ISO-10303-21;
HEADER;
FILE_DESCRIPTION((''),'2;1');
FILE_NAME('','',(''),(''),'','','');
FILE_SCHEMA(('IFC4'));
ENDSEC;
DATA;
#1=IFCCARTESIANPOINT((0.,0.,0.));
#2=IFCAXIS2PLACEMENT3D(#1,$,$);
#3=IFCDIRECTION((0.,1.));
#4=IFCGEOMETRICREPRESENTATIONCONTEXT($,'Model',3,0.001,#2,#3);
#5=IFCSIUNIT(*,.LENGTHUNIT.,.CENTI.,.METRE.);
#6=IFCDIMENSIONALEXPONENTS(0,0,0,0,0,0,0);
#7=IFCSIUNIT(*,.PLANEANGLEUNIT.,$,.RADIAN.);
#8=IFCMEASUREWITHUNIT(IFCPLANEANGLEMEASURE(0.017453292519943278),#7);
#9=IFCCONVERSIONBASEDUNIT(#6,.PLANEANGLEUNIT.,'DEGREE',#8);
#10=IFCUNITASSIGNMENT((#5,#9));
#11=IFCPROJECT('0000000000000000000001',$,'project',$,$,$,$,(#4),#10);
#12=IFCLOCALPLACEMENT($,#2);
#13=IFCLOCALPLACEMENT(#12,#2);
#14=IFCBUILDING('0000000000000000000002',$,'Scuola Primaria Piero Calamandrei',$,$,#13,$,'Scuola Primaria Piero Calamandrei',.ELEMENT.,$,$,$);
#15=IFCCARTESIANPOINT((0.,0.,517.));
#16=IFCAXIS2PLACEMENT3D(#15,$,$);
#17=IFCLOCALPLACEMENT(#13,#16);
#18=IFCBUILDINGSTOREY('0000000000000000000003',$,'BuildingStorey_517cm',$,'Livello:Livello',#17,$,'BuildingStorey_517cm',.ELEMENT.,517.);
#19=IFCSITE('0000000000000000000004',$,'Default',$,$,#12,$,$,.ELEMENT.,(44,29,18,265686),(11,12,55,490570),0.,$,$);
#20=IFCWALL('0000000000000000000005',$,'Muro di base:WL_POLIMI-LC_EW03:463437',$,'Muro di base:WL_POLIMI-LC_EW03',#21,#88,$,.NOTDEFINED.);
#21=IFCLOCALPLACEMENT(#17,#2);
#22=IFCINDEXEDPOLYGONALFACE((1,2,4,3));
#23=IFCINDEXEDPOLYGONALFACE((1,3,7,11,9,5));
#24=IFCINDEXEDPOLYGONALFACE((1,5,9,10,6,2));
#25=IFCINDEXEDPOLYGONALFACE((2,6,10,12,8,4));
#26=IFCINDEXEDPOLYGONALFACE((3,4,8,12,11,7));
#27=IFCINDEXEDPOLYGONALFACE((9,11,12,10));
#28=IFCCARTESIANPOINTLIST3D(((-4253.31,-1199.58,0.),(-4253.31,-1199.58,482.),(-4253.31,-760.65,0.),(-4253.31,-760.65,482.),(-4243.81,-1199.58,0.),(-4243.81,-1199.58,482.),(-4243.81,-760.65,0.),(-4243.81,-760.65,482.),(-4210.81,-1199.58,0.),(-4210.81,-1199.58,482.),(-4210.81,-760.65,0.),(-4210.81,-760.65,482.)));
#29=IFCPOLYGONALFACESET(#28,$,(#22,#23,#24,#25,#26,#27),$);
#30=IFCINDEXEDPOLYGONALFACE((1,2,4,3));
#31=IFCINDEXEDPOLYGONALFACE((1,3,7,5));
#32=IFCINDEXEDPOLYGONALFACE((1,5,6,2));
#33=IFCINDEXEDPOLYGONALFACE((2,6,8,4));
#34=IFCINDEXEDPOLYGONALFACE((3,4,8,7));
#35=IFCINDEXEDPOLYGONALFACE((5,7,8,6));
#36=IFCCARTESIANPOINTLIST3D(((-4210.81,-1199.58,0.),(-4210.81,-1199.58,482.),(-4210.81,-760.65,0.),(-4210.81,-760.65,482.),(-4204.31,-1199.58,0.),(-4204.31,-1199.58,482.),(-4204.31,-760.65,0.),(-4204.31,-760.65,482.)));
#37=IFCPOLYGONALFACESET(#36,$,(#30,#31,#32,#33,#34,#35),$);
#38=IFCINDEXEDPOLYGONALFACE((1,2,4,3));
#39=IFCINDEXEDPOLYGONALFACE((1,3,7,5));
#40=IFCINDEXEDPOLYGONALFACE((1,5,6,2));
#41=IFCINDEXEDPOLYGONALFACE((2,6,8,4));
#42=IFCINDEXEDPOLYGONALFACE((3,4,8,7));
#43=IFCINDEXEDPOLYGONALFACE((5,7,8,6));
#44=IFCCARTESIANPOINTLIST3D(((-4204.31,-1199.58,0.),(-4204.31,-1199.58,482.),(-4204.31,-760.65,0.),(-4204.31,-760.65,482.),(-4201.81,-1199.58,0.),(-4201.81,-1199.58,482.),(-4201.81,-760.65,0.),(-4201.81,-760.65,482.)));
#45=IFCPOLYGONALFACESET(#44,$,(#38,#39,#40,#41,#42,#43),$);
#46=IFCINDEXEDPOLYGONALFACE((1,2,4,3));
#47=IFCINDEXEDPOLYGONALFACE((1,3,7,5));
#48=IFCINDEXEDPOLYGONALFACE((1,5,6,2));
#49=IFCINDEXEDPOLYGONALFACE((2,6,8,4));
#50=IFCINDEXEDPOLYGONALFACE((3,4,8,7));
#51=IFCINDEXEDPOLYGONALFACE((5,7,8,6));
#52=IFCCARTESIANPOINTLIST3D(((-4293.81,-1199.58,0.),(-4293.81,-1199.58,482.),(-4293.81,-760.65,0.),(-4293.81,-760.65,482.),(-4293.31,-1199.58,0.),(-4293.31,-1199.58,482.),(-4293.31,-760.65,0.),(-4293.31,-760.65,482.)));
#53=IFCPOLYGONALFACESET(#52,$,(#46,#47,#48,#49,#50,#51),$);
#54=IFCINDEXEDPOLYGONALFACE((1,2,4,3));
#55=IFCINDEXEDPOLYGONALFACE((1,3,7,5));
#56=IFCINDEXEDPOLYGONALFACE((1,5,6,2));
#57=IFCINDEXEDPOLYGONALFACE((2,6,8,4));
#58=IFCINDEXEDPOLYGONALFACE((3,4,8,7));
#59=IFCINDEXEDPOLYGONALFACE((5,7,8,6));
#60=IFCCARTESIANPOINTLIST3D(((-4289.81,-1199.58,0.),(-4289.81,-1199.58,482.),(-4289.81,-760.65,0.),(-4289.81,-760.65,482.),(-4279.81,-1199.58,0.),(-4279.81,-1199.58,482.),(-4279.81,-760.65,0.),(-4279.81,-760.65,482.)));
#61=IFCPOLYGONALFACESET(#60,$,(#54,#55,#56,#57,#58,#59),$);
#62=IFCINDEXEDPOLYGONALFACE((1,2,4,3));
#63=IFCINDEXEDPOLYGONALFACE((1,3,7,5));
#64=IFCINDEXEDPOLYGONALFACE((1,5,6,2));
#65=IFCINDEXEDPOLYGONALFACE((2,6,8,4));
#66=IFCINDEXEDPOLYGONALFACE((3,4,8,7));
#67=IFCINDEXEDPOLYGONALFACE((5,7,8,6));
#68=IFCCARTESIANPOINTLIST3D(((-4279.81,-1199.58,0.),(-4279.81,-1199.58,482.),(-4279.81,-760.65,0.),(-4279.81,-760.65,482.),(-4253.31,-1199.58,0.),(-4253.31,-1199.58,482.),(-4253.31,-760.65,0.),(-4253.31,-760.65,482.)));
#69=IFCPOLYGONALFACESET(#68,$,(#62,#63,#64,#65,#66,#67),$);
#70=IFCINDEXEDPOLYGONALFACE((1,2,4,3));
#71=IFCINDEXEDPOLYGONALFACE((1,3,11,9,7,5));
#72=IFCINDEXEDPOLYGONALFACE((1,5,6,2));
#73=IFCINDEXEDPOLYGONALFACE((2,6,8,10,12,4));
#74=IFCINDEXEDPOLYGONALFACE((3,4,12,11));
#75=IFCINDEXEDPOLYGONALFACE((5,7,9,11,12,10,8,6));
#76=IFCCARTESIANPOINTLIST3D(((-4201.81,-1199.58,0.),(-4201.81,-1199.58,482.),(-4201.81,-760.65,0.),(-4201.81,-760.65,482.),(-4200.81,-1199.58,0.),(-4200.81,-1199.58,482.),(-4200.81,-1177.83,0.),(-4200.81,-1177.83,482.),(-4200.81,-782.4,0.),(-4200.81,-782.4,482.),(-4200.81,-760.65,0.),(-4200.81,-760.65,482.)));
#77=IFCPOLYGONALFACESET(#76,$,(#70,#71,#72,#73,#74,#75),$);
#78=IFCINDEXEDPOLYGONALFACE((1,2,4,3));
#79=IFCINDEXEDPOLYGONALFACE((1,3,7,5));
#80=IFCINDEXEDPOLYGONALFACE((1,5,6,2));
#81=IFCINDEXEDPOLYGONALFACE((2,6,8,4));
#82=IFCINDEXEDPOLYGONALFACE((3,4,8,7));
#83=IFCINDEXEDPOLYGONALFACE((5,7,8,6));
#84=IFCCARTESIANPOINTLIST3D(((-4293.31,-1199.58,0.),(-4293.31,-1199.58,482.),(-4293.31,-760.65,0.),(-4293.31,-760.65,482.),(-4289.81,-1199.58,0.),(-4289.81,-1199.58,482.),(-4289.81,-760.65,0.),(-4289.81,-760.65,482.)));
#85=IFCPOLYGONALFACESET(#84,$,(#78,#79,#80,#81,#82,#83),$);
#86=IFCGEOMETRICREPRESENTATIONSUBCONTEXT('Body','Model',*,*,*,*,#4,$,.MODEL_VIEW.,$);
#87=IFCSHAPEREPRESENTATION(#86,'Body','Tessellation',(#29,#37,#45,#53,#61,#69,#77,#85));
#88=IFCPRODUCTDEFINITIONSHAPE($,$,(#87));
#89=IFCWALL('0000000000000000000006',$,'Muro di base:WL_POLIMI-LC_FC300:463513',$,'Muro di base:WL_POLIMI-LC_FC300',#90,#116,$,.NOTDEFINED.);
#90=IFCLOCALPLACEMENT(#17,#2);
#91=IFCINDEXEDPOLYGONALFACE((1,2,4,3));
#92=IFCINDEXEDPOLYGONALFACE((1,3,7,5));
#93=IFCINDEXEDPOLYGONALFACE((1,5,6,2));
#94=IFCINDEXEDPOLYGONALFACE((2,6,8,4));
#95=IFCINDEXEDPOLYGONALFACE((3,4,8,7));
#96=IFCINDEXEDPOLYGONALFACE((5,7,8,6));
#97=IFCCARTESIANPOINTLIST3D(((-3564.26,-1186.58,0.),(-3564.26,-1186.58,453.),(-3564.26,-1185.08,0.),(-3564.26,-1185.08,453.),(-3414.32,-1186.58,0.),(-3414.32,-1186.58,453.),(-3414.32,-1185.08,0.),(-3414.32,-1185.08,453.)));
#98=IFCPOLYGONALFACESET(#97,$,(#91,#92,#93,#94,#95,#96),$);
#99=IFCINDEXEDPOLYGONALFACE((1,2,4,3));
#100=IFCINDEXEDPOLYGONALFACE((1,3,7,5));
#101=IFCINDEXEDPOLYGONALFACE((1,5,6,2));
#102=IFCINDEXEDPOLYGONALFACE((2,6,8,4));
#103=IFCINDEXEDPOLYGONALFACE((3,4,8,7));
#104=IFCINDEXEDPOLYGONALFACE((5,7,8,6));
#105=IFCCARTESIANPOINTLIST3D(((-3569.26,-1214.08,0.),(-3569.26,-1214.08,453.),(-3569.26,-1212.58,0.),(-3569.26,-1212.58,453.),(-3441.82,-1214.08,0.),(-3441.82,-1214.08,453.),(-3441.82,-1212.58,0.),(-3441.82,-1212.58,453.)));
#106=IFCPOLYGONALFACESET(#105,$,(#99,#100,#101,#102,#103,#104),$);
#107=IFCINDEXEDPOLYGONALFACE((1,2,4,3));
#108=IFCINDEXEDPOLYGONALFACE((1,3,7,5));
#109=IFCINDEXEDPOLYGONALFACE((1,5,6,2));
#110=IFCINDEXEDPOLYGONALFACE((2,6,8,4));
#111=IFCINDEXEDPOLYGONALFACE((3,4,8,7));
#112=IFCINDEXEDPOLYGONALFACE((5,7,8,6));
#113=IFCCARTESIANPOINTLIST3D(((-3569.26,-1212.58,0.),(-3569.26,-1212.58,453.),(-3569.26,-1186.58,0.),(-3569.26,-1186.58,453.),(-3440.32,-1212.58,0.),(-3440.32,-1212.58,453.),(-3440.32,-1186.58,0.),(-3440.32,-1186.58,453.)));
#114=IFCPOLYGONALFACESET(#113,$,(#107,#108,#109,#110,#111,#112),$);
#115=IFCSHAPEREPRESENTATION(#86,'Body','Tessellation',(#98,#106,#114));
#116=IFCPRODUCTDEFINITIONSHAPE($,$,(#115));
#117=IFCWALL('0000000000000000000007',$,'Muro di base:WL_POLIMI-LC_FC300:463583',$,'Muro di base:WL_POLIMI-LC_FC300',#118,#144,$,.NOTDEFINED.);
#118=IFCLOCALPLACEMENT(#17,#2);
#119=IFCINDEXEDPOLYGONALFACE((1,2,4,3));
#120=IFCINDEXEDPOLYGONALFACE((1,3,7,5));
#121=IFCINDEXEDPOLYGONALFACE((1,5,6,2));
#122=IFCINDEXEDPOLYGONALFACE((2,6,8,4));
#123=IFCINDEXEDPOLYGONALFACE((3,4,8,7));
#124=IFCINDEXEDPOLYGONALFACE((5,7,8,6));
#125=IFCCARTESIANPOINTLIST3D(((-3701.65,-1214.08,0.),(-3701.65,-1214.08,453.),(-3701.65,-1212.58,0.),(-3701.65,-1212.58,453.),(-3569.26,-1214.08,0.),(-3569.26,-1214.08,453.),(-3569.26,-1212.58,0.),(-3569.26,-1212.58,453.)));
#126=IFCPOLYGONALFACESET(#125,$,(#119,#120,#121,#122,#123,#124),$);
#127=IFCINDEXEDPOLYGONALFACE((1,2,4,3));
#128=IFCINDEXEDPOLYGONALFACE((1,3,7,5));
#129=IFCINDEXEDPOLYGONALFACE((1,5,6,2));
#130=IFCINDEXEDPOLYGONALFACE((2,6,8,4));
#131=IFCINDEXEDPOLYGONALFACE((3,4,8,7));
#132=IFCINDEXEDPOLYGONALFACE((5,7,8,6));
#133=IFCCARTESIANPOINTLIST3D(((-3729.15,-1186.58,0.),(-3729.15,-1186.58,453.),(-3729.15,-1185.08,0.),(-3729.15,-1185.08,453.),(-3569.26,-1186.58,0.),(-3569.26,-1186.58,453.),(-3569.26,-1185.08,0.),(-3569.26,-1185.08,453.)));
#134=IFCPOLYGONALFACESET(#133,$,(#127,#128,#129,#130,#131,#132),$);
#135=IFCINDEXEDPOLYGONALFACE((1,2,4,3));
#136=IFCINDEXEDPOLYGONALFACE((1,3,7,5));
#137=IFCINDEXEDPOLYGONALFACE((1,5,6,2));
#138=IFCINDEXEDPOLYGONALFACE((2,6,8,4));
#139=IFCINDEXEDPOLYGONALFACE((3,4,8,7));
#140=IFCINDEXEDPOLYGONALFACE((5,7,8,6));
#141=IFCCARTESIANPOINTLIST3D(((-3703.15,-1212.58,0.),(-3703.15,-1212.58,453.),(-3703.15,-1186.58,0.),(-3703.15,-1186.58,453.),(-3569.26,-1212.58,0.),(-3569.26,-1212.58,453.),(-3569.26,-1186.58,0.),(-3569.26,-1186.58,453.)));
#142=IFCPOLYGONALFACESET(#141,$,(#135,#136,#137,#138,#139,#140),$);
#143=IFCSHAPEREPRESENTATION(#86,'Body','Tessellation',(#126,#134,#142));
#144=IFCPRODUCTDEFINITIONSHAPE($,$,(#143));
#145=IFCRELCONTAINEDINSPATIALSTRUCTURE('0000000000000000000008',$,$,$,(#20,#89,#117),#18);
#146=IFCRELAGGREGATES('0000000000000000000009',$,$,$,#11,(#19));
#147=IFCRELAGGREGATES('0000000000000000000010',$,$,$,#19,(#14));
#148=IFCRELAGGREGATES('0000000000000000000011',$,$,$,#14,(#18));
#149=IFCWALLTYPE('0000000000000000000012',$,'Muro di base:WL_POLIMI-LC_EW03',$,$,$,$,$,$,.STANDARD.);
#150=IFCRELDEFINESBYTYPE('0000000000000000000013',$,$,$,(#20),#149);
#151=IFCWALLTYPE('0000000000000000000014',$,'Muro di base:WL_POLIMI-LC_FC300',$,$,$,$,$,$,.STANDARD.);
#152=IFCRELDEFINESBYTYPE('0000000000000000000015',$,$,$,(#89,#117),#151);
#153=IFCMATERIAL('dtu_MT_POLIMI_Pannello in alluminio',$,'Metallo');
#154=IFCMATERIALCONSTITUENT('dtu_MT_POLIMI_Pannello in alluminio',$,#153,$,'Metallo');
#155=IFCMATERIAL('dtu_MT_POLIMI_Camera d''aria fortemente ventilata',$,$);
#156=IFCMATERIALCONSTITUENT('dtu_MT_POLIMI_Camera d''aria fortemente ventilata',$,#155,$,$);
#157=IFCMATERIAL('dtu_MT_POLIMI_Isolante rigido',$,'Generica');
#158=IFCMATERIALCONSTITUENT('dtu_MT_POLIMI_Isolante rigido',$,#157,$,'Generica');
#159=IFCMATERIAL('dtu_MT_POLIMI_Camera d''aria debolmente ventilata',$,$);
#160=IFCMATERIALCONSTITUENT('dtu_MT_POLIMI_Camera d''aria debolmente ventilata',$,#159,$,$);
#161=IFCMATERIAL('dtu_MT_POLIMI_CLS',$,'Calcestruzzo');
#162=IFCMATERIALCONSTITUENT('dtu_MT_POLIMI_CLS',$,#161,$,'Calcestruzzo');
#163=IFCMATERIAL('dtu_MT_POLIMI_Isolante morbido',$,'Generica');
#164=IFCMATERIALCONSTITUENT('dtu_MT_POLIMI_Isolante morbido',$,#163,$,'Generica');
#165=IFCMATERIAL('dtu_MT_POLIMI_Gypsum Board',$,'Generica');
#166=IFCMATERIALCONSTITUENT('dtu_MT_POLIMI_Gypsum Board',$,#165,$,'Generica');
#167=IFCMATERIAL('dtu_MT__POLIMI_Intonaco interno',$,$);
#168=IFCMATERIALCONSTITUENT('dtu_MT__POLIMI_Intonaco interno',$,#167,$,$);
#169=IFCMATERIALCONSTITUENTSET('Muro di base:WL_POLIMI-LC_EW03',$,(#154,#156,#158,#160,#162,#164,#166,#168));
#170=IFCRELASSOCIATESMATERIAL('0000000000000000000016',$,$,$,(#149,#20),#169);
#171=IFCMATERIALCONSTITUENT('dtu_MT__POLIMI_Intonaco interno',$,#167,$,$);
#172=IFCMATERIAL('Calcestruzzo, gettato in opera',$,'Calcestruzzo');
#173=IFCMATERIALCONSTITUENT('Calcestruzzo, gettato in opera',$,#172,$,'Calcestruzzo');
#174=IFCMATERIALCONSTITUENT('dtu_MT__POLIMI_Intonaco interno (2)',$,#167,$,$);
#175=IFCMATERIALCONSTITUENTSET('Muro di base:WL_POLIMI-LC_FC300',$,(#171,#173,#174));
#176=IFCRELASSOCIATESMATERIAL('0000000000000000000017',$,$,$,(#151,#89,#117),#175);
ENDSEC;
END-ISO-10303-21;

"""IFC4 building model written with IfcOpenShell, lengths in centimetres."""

from ifc_helpers import new_model, entity, si_unit, converted_unit, direction, frame, origin, place, context, subcontext, project, spatial, indexed_curve, outline, extrude, material, constituent, constituent_set, type_object, element, save


model = new_model("IFC4")

# Units and contexts
model_context = context("Model", 3, precision=0.001, world=origin(), true_north=direction((0.0, 1.0)))
body_context = subcontext(model_context, "Body", "Model", "MODEL_VIEW")
ifc_project = project(units=[si_unit("LENGTHUNIT", "METRE", prefix="CENTI"), converted_unit("PLANEANGLEUNIT", "DEGREE", entity("IfcPlaneAngleMeasure", 0.017453292519943278), si_unit("PLANEANGLEUNIT", "RADIAN"), dimensions=[0, 0, 0, 0, 0, 0, 0])], contexts=[model_context])

# Site, building, storey
site_placement = place(None, origin())
site = spatial("IfcSite", under=ifc_project, at=site_placement, Name="Default", CompositionType="ELEMENT", RefLatitude=(44, 29, 18, 265686), RefLongitude=(11, 12, 55, 490570), RefElevation=0.0)
building_placement = place(site_placement, origin())
building = spatial("IfcBuilding", under=site, at=building_placement, Name="Scuola Primaria Piero Calamandrei", LongName="Scuola Primaria Piero Calamandrei", CompositionType="ELEMENT")
storey_placement = place(building_placement, frame((0.0, 0.0, 517.0)))
storey = spatial("IfcBuildingStorey", under=building, at=storey_placement, Name="BuildingStorey_517cm", ObjectType="Livello:Livello", LongName="BuildingStorey_517cm", CompositionType="ELEMENT", Elevation=517.0)

# Wall
ifc_material_1 = material(Name="dtu_MT_POLIMI_Pannello in alluminio", Category="Metallo")
ifc_material_2 = material(Name="dtu_MT_POLIMI_Camera d'aria fortemente ventilata")
ifc_material_3 = material(Name="dtu_MT_POLIMI_Isolante rigido", Category="Generica")
ifc_material_4 = material(Name="dtu_MT_POLIMI_Camera d'aria debolmente ventilata")
ifc_material_5 = material(Name="dtu_MT_POLIMI_Isolante morbido", Category="Generica")
ifc_material_6 = material(Name="dtu_MT_POLIMI_Gypsum Board", Category="Generica")
ifc_material_7 = material(Name="dtu_MT__POLIMI_Intonaco interno")
ifc_constituent_1 = constituent(ifc_material_1, Name="dtu_MT_POLIMI_Pannello in alluminio", Category="Metallo")
ifc_constituent_2 = constituent(ifc_material_2, Name="dtu_MT_POLIMI_Camera d'aria fortemente ventilata")
ifc_constituent_3 = constituent(ifc_material_3, Name="dtu_MT_POLIMI_Isolante rigido", Category="Generica")
ifc_constituent_4 = constituent(ifc_material_4, Name="dtu_MT_POLIMI_Camera d'aria debolmente ventilata")
ifc_material_8 = material(Name="dtu_MT_POLIMI_CLS", Category="Calcestruzzo")
ifc_constituent_5 = constituent(ifc_material_8, Name="dtu_MT_POLIMI_CLS", Category="Calcestruzzo")
ifc_constituent_6 = constituent(ifc_material_5, Name="dtu_MT_POLIMI_Isolante morbido", Category="Generica")
ifc_constituent_7 = constituent(ifc_material_6, Name="dtu_MT_POLIMI_Gypsum Board", Category="Generica")
ifc_constituent_8 = constituent(ifc_material_7, Name="dtu_MT__POLIMI_Intonaco interno")
ifc_constituent_set_1 = constituent_set(constituents=[ifc_constituent_1, ifc_constituent_2, ifc_constituent_3, ifc_constituent_4, ifc_constituent_5, ifc_constituent_6, ifc_constituent_7, ifc_constituent_8], Name="Muro di base:WL_POLIMI-LC_EW03")
wall_type_1 = type_object("IfcWallType", Name="Muro di base:WL_POLIMI-LC_EW03", PredefinedType="STANDARD", material=ifc_constituent_set_1)
wall_1_placement = place(storey_placement, frame((-4247.31, -1199.58, 0.0), z_axis=(0.0, 0.0, 1.0), x_axis=(0.0, 1.0, 0.0)))
element("IfcWall", 1, at=wall_1_placement, inside=storey, type_object=wall_type_1, material=ifc_constituent_set_1, Name="Muro di base:WL_POLIMI-LC_EW03:463437", ObjectType="Muro di base:WL_POLIMI-LC_EW03", PredefinedType="NOTDEFINED", context=body_context, shape_type="SweptSolid", body=[
    extrude(outline(indexed_curve([(-17.33, -219.46), (-7.83, -219.46), (25.17, -219.46), (25.17, 219.46), (-7.83, 219.46), (-17.33, 219.46), (-17.33, -219.46)], self_intersect=False)), frame((219.46, -11.33, 0.0), z_axis=(0.0, 0.0, 1.0), x_axis=(0.0, -1.0, 0.0)), (0.0, 0.0, 1.0), 482.0),
    extrude(outline(indexed_curve([(-3.25, -219.46), (3.25, -219.46), (3.25, 219.46), (-3.25, 219.46), (-3.25, -219.46)], self_intersect=False)), frame((219.46, -39.75, 0.0), z_axis=(0.0, 0.0, 1.0), x_axis=(0.0, 1.0, 0.0)), (0.0, 0.0, 1.0), 482.0),
    extrude(outline(indexed_curve([(-1.25, -219.46), (1.25, -219.46), (1.25, 219.46), (-1.25, 219.46), (-1.25, -219.46)], self_intersect=False)), frame((219.46, -44.25, 0.0), z_axis=(0.0, 0.0, 1.0), x_axis=(0.0, 1.0, 0.0)), (0.0, 0.0, 1.0), 482.0),
    extrude(outline(indexed_curve([(-0.25, -219.46), (0.25, -219.46), (0.25, 219.46), (-0.25, 219.46), (-0.25, -219.46)], self_intersect=False)), frame((219.46, 46.25, 0.0), z_axis=(0.0, 0.0, 1.0), x_axis=(0.0, 1.0, 0.0)), (0.0, 0.0, 1.0), 482.0),
    extrude(outline(indexed_curve([(-5.0, -219.46), (5.0, -219.46), (5.0, 219.46), (-5.0, 219.46), (-5.0, -219.46)], self_intersect=False)), frame((219.46, 37.5, 0.0), z_axis=(0.0, 0.0, 1.0), x_axis=(0.0, -1.0, 0.0)), (0.0, 0.0, 1.0), 482.0),
    extrude(outline(indexed_curve([(-13.25, -219.46), (13.25, -219.46), (13.25, 219.46), (-13.25, 219.46), (-13.25, -219.46)], self_intersect=False)), frame((219.46, 19.25, 0.0), z_axis=(0.0, 0.0, 1.0), x_axis=(0.0, 1.0, 0.0)), (0.0, 0.0, 1.0), 482.0),
    extrude(outline(indexed_curve([(-0.67, -219.46), (0.33, -219.46), (0.33, -197.71), (0.33, 197.71), (0.33, 219.46), (-0.67, 219.46), (-0.67, -219.46)], self_intersect=False)), frame((219.46, -46.17, 0.0), z_axis=(0.0, 0.0, 1.0), x_axis=(0.0, -1.0, 0.0)), (0.0, 0.0, 1.0), 482.0),
    extrude(outline(indexed_curve([(-1.75, -219.46), (1.75, -219.46), (1.75, 219.46), (-1.75, 219.46), (-1.75, -219.46)], self_intersect=False)), frame((219.46, 44.25, 0.0), z_axis=(0.0, 0.0, 1.0), x_axis=(0.0, -1.0, 0.0)), (0.0, 0.0, 1.0), 482.0),
])

# Shared definitions
ifc_constituent_9 = constituent(ifc_material_7, Name="dtu_MT__POLIMI_Intonaco interno")
ifc_material_9 = material(Name="Calcestruzzo, gettato in opera", Category="Calcestruzzo")
ifc_constituent_10 = constituent(ifc_material_9, Name="Calcestruzzo, gettato in opera", Category="Calcestruzzo")
ifc_constituent_11 = constituent(ifc_material_7, Name="dtu_MT__POLIMI_Intonaco interno (2)")
ifc_constituent_set_2 = constituent_set(constituents=[ifc_constituent_9, ifc_constituent_10, ifc_constituent_11], Name="Muro di base:WL_POLIMI-LC_FC300")
wall_type_2 = type_object("IfcWallType", Name="Muro di base:WL_POLIMI-LC_FC300", PredefinedType="STANDARD", material=ifc_constituent_set_2)

# Walls
wall_2_placement = place(storey_placement, frame((-3441.82, -1199.58, 0.0), z_axis=(0.0, 0.0, 1.0), x_axis=(-1.0, 0.0, 0.0)))
element("IfcWall", 2, at=wall_2_placement, inside=storey, type_object=wall_type_2, material=ifc_constituent_set_2, Name="Muro di base:WL_POLIMI-LC_FC300:463513", ObjectType="Muro di base:WL_POLIMI-LC_FC300", PredefinedType="NOTDEFINED", context=body_context, shape_type="SweptSolid", body=[
    extrude(outline(indexed_curve([(-0.75, -74.97), (0.75, -74.97), (0.75, 74.97), (-0.75, 74.97), (-0.75, -74.97)], self_intersect=False)), frame((47.47, -13.75, 0.0), z_axis=(0.0, 0.0, 1.0), x_axis=(0.0, 1.0, 0.0)), (0.0, 0.0, 1.0), 453.0),
    extrude(outline(indexed_curve([(-0.75, -63.72), (0.75, -63.72), (0.75, 63.72), (-0.75, 63.72), (-0.75, -63.72)], self_intersect=False)), frame((63.72, 13.75, 0.0), z_axis=(0.0, 0.0, 1.0), x_axis=(0.0, -1.0, 0.0)), (0.0, 0.0, 1.0), 453.0),
    extrude(outline(indexed_curve([(-64.47, -13.0), (64.47, -13.0), (64.47, 13.0), (-64.47, 13.0), (-64.47, -13.0)], self_intersect=False)), frame((62.97, 0.0, 0.0)), (0.0, 0.0, 1.0), 453.0),
])
wall_3_placement = place(storey_placement, frame((-3701.65, -1199.58, 0.0)))
element("IfcWall", 3, at=wall_3_placement, inside=storey, type_object=wall_type_2, material=ifc_constituent_set_2, Name="Muro di base:WL_POLIMI-LC_FC300:463583", ObjectType="Muro di base:WL_POLIMI-LC_FC300", PredefinedType="NOTDEFINED", context=body_context, shape_type="SweptSolid", body=[
    extrude(outline(indexed_curve([(-0.75, -66.2), (0.75, -66.2), (0.75, 66.2), (-0.75, 66.2), (-0.75, -66.2)], self_intersect=False)), frame((66.2, -13.75, 0.0), z_axis=(0.0, 0.0, 1.0), x_axis=(0.0, 1.0, 0.0)), (0.0, 0.0, 1.0), 453.0),
    extrude(outline(indexed_curve([(-0.75, -79.95), (0.75, -79.95), (0.75, 79.95), (-0.75, 79.95), (-0.75, -79.95)], self_intersect=False)), frame((52.45, 13.75, 0.0), z_axis=(0.0, 0.0, 1.0), x_axis=(0.0, -1.0, 0.0)), (0.0, 0.0, 1.0), 453.0),
    extrude(outline(indexed_curve([(-66.95, -13.0), (66.95, -13.0), (66.95, 13.0), (-66.95, 13.0), (-66.95, -13.0)], self_intersect=False)), frame((65.45, 0.0, 0.0)), (0.0, 0.0, 1.0), 453.0),
])

save(model, "model.ifc")
